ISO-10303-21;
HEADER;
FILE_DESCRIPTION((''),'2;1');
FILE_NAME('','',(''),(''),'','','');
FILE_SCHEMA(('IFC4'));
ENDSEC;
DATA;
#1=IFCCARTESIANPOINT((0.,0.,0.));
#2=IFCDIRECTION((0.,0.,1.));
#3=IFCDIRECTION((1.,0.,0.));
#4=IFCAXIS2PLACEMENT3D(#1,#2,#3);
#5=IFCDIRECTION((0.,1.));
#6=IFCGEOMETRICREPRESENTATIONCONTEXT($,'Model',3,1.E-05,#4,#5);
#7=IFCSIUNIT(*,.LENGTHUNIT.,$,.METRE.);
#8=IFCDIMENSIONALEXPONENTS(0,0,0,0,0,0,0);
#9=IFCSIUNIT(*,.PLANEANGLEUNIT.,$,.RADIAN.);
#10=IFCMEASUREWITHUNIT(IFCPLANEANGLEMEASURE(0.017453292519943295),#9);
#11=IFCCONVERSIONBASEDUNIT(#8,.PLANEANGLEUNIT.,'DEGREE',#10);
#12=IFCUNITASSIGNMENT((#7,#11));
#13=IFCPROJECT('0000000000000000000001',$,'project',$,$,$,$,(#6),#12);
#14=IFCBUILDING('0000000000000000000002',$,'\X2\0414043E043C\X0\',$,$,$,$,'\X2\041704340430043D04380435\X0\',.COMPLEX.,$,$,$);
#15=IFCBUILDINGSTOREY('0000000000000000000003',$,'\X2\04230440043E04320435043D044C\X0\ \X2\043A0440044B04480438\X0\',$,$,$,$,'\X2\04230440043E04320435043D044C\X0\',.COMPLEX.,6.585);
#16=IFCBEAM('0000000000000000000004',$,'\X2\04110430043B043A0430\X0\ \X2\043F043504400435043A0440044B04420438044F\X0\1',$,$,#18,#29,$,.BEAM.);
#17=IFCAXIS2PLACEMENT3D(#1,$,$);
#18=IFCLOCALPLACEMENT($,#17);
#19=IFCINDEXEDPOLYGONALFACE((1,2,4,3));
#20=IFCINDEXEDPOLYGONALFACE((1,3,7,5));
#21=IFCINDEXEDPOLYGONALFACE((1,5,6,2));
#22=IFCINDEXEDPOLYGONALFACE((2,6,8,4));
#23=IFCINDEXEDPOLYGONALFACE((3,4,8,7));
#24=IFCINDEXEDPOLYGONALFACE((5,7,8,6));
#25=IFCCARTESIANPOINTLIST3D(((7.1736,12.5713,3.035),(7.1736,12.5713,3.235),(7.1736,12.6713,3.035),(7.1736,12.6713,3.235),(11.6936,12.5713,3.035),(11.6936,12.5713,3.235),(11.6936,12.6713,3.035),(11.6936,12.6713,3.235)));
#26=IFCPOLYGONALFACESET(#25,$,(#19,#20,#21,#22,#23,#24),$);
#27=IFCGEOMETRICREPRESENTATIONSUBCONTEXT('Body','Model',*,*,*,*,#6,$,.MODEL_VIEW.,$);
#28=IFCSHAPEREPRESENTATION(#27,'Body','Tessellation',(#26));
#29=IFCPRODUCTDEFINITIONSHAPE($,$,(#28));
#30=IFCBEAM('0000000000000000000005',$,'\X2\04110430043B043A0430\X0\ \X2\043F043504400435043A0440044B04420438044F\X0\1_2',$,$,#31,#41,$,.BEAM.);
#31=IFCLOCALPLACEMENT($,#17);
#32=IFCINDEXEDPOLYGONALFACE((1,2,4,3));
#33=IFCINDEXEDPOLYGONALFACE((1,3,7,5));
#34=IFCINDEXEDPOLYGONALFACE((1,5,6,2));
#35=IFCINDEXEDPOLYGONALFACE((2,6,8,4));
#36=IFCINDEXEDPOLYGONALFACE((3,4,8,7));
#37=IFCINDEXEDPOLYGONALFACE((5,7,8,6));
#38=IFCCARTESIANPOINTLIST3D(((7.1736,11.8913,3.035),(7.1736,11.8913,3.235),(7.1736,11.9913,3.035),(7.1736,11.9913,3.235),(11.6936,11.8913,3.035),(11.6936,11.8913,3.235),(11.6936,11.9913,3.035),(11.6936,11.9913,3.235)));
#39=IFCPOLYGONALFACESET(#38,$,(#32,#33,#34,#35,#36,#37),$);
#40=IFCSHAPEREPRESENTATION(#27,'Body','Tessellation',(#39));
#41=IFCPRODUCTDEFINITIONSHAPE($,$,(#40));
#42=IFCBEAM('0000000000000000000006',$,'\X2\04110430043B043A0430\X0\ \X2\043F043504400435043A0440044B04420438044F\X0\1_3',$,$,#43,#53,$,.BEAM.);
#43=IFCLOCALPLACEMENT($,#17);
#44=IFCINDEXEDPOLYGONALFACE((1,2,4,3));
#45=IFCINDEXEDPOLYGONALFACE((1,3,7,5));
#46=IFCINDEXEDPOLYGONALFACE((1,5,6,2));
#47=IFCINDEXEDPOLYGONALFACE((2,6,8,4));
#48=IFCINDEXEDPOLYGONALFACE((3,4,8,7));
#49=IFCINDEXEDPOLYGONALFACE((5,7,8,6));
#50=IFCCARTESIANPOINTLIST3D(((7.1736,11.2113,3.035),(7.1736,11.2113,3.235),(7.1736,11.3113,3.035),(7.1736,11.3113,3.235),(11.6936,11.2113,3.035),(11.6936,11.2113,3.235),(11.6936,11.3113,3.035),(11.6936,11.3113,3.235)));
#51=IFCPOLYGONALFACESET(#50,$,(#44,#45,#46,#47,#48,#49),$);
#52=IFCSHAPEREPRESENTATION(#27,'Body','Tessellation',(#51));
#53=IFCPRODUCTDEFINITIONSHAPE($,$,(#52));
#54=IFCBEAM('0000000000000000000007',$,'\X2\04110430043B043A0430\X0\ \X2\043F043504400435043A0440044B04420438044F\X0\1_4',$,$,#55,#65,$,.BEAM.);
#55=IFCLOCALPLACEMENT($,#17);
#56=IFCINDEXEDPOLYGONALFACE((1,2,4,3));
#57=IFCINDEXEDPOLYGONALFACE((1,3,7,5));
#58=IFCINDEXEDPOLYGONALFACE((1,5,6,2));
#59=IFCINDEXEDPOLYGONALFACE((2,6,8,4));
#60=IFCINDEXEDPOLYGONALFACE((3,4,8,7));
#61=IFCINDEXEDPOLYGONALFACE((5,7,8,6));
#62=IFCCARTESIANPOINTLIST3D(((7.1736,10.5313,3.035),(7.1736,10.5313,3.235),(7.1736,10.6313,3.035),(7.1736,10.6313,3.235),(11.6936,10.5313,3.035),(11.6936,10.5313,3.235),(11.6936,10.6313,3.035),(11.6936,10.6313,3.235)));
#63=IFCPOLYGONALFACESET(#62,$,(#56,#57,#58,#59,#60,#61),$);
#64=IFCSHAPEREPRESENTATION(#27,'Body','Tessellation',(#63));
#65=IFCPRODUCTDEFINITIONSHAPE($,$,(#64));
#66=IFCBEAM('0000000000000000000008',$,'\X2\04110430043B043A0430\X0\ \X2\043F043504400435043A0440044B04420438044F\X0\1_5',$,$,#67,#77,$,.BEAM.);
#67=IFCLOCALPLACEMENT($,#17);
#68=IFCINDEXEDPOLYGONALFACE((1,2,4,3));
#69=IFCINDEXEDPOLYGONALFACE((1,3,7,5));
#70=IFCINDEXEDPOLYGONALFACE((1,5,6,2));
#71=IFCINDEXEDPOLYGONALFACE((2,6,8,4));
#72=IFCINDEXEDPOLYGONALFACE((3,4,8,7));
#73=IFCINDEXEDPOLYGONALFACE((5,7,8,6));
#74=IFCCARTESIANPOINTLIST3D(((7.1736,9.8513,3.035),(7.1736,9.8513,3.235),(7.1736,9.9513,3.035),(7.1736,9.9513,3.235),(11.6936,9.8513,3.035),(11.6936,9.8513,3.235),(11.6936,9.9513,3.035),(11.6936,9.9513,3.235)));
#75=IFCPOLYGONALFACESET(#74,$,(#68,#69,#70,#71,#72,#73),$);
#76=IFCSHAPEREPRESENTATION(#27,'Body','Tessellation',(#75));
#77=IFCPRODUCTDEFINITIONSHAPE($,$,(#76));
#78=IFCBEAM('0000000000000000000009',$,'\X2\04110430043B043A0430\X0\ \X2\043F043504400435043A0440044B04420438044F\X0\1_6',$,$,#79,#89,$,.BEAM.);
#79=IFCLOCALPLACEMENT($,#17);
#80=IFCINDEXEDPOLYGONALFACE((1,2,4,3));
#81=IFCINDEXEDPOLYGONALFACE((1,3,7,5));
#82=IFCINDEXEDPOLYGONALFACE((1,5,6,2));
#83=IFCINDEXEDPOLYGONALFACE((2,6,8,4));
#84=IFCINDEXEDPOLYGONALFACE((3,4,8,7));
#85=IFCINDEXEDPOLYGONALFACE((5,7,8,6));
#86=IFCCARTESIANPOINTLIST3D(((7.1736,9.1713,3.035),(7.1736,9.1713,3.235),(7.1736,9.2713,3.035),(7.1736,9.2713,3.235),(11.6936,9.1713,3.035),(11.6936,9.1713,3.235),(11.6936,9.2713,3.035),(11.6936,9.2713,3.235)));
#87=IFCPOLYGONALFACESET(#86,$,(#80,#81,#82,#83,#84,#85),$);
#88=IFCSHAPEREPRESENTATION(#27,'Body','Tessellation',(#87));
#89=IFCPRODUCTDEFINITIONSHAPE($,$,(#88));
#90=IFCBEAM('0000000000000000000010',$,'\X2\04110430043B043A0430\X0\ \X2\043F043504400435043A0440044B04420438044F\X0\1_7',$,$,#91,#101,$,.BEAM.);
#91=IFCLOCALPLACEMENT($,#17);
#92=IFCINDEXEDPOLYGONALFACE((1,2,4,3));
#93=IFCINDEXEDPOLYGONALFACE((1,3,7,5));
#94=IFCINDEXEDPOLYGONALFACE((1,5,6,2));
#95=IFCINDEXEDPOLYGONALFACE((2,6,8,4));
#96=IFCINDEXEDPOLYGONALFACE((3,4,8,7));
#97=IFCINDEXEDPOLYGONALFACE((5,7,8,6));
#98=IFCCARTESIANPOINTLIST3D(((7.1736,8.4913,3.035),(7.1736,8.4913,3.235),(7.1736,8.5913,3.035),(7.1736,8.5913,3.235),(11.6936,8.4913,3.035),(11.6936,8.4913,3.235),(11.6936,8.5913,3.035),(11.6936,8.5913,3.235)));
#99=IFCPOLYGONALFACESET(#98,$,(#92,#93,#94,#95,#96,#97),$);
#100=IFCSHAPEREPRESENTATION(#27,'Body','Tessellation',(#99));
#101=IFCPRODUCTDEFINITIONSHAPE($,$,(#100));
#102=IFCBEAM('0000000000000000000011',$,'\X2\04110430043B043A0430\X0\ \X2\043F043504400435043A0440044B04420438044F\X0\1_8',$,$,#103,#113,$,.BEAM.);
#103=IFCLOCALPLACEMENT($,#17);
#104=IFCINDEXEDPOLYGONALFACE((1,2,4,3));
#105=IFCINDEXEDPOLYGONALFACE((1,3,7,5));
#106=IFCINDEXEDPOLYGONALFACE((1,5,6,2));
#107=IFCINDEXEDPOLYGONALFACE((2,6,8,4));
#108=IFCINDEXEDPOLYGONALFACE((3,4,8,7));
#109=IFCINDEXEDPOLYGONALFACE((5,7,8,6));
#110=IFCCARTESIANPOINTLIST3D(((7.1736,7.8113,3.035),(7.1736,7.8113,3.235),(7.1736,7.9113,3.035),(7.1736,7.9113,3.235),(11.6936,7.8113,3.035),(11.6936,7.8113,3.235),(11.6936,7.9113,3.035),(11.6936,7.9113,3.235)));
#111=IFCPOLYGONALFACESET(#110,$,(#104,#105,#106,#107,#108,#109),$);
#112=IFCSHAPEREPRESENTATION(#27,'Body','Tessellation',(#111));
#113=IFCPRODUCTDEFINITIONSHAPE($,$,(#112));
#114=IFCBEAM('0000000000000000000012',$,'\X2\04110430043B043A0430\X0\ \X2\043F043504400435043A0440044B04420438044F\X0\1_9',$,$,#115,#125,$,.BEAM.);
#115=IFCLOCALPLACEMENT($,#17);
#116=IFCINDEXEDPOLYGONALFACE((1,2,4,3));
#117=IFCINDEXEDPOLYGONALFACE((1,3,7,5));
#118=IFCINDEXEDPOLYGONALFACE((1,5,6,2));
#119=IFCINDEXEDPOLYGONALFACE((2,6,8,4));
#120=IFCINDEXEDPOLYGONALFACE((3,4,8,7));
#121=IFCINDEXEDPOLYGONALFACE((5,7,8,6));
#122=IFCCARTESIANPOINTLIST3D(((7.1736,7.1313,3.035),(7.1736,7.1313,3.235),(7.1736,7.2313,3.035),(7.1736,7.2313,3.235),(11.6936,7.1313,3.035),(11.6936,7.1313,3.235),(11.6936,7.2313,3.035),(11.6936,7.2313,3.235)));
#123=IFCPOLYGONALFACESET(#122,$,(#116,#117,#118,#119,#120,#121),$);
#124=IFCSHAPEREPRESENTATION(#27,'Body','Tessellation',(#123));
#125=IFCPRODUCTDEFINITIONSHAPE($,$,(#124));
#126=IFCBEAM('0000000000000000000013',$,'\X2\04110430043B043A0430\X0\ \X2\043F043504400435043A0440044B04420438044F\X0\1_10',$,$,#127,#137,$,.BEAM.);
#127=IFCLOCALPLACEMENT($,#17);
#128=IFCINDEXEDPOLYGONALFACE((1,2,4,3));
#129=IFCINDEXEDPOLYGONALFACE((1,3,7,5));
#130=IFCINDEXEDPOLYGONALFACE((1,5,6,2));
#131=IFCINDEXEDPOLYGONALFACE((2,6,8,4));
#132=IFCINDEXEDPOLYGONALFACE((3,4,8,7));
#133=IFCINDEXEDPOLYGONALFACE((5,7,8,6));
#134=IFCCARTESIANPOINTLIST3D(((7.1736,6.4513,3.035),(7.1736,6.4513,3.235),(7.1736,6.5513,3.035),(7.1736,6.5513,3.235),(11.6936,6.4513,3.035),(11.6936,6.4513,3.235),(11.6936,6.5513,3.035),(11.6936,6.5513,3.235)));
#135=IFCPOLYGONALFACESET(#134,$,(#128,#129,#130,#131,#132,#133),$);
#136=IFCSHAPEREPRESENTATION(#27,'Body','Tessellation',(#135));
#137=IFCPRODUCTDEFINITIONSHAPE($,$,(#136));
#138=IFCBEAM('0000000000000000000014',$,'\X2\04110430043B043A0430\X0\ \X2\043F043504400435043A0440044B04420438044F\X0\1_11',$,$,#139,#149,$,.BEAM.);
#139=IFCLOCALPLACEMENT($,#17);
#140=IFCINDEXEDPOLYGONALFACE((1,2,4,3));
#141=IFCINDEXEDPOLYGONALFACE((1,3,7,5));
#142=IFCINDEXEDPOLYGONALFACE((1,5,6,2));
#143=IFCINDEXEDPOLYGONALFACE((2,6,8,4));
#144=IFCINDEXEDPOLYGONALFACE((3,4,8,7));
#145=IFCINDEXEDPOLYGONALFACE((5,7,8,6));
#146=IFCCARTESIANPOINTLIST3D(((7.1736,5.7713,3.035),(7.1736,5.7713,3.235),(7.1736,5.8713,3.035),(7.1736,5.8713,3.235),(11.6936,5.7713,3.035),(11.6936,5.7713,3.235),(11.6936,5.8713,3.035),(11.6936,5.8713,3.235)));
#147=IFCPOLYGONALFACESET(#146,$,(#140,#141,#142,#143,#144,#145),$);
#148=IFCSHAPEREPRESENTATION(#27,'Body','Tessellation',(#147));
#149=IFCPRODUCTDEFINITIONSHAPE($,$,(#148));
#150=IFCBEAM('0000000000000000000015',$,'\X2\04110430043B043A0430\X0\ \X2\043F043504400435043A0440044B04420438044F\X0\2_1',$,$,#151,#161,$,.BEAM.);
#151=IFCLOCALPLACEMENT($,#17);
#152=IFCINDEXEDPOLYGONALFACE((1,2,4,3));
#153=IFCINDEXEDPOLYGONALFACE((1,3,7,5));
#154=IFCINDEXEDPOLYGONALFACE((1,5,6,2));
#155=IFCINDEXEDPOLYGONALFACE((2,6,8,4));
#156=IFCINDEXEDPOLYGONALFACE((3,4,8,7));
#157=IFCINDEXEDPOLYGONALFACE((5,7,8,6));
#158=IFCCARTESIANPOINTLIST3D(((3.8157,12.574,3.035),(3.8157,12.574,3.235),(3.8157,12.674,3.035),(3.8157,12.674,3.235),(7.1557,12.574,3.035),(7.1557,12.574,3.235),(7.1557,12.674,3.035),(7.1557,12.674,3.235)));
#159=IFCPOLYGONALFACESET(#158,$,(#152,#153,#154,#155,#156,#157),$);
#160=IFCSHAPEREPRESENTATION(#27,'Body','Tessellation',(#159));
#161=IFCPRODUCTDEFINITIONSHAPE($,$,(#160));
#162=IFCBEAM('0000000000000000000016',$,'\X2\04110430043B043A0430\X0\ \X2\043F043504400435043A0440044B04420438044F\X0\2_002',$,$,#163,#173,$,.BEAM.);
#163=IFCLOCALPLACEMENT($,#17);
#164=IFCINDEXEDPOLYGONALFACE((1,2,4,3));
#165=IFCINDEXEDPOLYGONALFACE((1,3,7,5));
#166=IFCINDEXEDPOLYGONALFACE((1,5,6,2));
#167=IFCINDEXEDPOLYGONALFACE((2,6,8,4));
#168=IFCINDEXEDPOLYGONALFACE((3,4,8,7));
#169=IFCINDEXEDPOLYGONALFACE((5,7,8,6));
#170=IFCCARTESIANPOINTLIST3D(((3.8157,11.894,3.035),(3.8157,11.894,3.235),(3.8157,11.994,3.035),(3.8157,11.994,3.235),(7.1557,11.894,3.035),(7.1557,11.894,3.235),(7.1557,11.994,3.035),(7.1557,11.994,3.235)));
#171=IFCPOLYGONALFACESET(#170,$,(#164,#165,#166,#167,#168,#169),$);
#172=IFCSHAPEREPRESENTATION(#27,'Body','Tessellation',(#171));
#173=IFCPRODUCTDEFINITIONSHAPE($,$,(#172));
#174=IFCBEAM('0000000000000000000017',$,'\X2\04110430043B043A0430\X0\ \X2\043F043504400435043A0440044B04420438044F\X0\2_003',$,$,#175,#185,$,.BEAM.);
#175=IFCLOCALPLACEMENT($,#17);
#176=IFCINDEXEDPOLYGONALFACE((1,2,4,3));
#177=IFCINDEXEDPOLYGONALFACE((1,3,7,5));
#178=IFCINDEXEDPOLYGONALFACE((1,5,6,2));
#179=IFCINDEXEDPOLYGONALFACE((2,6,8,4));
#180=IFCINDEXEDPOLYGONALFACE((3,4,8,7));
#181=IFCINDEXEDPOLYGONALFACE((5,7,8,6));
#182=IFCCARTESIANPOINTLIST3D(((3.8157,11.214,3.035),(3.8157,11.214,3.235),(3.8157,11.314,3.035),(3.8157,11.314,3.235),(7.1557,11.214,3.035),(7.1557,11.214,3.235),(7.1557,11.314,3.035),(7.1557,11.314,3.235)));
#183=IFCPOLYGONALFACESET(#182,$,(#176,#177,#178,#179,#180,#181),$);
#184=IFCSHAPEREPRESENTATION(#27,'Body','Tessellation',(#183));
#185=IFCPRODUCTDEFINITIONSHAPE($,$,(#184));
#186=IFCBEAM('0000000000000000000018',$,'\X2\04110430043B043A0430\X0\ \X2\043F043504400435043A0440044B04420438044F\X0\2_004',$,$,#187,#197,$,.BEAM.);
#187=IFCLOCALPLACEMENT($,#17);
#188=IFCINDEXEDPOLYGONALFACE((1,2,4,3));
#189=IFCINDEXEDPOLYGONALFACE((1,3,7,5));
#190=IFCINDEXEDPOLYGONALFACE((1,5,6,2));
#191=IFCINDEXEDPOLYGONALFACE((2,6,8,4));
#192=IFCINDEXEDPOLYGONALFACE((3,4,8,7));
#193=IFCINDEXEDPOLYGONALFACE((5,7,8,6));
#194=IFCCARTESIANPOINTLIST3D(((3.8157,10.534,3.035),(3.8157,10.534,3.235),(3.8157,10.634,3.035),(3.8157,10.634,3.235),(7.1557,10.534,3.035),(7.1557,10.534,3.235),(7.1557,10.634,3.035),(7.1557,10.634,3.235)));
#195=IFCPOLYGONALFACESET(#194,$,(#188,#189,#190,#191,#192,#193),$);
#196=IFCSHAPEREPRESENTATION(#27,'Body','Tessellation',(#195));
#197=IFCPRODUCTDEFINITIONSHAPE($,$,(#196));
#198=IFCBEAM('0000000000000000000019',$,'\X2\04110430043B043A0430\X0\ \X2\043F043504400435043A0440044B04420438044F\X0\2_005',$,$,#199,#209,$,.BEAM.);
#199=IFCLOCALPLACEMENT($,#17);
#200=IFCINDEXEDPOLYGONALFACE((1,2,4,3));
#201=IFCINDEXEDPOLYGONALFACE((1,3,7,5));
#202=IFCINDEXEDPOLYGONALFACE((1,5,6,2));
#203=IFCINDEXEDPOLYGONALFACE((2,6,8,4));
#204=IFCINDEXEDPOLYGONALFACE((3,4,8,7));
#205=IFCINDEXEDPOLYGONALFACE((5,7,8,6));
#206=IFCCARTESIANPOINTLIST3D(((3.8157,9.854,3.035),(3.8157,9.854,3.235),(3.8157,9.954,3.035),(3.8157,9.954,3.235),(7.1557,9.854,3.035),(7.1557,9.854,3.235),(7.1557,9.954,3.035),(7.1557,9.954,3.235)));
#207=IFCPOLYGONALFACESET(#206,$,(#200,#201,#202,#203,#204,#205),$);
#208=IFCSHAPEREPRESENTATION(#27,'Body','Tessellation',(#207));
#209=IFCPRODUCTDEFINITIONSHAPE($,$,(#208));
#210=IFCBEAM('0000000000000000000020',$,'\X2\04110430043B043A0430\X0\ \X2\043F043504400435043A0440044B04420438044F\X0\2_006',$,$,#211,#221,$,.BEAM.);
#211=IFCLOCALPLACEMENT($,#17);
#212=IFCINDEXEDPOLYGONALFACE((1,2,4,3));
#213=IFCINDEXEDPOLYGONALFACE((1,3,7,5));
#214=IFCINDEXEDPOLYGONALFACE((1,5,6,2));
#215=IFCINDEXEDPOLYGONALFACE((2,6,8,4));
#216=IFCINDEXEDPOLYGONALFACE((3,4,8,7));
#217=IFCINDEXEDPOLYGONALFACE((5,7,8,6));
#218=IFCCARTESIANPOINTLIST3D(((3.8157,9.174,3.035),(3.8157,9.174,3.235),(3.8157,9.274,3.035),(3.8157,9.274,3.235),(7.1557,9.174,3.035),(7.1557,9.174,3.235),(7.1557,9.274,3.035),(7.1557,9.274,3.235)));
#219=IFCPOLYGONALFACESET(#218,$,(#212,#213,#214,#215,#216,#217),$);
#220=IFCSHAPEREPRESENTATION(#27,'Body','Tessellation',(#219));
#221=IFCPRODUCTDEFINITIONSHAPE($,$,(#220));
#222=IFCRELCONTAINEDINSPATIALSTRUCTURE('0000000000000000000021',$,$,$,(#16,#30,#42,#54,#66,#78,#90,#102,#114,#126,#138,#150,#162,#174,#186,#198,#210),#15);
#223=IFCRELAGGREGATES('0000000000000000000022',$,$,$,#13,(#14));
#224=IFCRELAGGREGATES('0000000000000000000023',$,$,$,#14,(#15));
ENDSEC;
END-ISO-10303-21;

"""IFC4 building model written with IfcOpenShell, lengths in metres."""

from ifc_helpers import new_model, entity, si_unit, converted_unit, direction, frame, frame_2d, origin_with_axes, origin_2d_with_axis, place, context, subcontext, project, spatial, rectangle, extrude, element, save


model = new_model("IFC4")

# Units and contexts
model_context = context("Model", 3, precision=1e-05, world=origin_with_axes(), true_north=direction((0.0, 1.0)))
body_context = subcontext(model_context, "Body", "Model", "MODEL_VIEW")
ifc_project = project(units=[si_unit("LENGTHUNIT", "METRE"), converted_unit("PLANEANGLEUNIT", "DEGREE", entity("IfcPlaneAngleMeasure", 0.017453292519943295), si_unit("PLANEANGLEUNIT", "RADIAN"), dimensions=[0, 0, 0, 0, 0, 0, 0])], contexts=[model_context])

# Building, storey
building = spatial("IfcBuilding", under=ifc_project, Name="Дом", LongName="Здание", CompositionType="COMPLEX")
storey = spatial("IfcBuildingStorey", under=building, Name="Уровень крыши", LongName="Уровень", CompositionType="COMPLEX", Elevation=6.585)

# Beams
placement = place(None, origin_with_axes())
element("IfcBeam", 1, at=placement, inside=storey, Name="Балка перекрытия1", PredefinedType="BEAM", context=body_context, shape_type="SweptSolid", body=[
    extrude(rectangle(XDim=4.52, YDim=0.1, at=origin_2d_with_axis()), frame((9.4336, 12.6213, 3.035), z_axis=(0.0, 0.0, 1.0), x_axis=(1.0, 0.0, 0.0)), (0.0, 0.0, 1.0), 0.2),
])
element("IfcBeam", 2, at=placement, inside=storey, Name="Балка перекрытия1_2", PredefinedType="BEAM", context=body_context, shape_type="SweptSolid", body=[
    extrude(rectangle(XDim=4.52, YDim=0.1, at=origin_2d_with_axis()), frame((9.4336, 11.9413, 3.035), z_axis=(0.0, 0.0, 1.0), x_axis=(1.0, 0.0, 0.0)), (0.0, 0.0, 1.0), 0.2),
])
element("IfcBeam", 3, at=placement, inside=storey, Name="Балка перекрытия1_3", PredefinedType="BEAM", context=body_context, shape_type="SweptSolid", body=[
    extrude(rectangle(XDim=4.52, YDim=0.1, at=origin_2d_with_axis()), frame((9.4336, 11.2613, 3.035), z_axis=(0.0, 0.0, 1.0), x_axis=(1.0, 0.0, 0.0)), (0.0, 0.0, 1.0), 0.2),
])
element("IfcBeam", 4, at=placement, inside=storey, Name="Балка перекрытия1_4", PredefinedType="BEAM", context=body_context, shape_type="SweptSolid", body=[
    extrude(rectangle(XDim=4.52, YDim=0.1, at=origin_2d_with_axis()), frame((9.4336, 10.5813, 3.035), z_axis=(0.0, 0.0, 1.0), x_axis=(1.0, 0.0, 0.0)), (0.0, 0.0, 1.0), 0.2),
])
element("IfcBeam", 5, at=placement, inside=storey, Name="Балка перекрытия1_5", PredefinedType="BEAM", context=body_context, shape_type="SweptSolid", body=[
    extrude(rectangle(XDim=4.52, YDim=0.1, at=origin_2d_with_axis()), frame((9.4336, 9.9013, 3.035), z_axis=(0.0, 0.0, 1.0), x_axis=(1.0, 0.0, 0.0)), (0.0, 0.0, 1.0), 0.2),
])
element("IfcBeam", 6, at=placement, inside=storey, Name="Балка перекрытия1_6", PredefinedType="BEAM", context=body_context, shape_type="SweptSolid", body=[
    extrude(rectangle(XDim=4.52, YDim=0.1, at=origin_2d_with_axis()), frame((9.4336, 9.2213, 3.035), z_axis=(0.0, 0.0, 1.0), x_axis=(1.0, 0.0, 0.0)), (0.0, 0.0, 1.0), 0.2),
])
element("IfcBeam", 7, at=placement, inside=storey, Name="Балка перекрытия1_7", PredefinedType="BEAM", context=body_context, shape_type="SweptSolid", body=[
    extrude(rectangle(XDim=4.52, YDim=0.1, at=origin_2d_with_axis()), frame((9.4336, 8.5413, 3.035), z_axis=(0.0, 0.0, 1.0), x_axis=(1.0, 0.0, 0.0)), (0.0, 0.0, 1.0), 0.2),
])
element("IfcBeam", 8, at=placement, inside=storey, Name="Балка перекрытия1_8", PredefinedType="BEAM", context=body_context, shape_type="SweptSolid", body=[
    extrude(rectangle(XDim=4.52, YDim=0.1, at=origin_2d_with_axis()), frame((9.4336, 7.8613, 3.035), z_axis=(0.0, 0.0, 1.0), x_axis=(1.0, 0.0, 0.0)), (0.0, 0.0, 1.0), 0.2),
])
element("IfcBeam", 9, at=placement, inside=storey, Name="Балка перекрытия1_9", PredefinedType="BEAM", context=body_context, shape_type="SweptSolid", body=[
    extrude(rectangle(XDim=4.52, YDim=0.1, at=origin_2d_with_axis()), frame((9.4336, 7.1813, 3.035), z_axis=(0.0, 0.0, 1.0), x_axis=(1.0, 0.0, 0.0)), (0.0, 0.0, 1.0), 0.2),
])
element("IfcBeam", 10, at=placement, inside=storey, Name="Балка перекрытия1_10", PredefinedType="BEAM", context=body_context, shape_type="SweptSolid", body=[
    extrude(rectangle(XDim=4.52, YDim=0.1, at=origin_2d_with_axis()), frame((9.4336, 6.5013, 3.035), z_axis=(0.0, 0.0, 1.0), x_axis=(1.0, 0.0, 0.0)), (0.0, 0.0, 1.0), 0.2),
])
element("IfcBeam", 11, at=placement, inside=storey, Name="Балка перекрытия1_11", PredefinedType="BEAM", context=body_context, shape_type="SweptSolid", body=[
    extrude(rectangle(XDim=4.52, YDim=0.1, at=origin_2d_with_axis()), frame((9.4336, 5.8213, 3.035), z_axis=(0.0, 0.0, 1.0), x_axis=(1.0, 0.0, 0.0)), (0.0, 0.0, 1.0), 0.2),
])
element("IfcBeam", 12, at=placement, inside=storey, Name="Балка перекрытия2_1", PredefinedType="BEAM", context=body_context, shape_type="SweptSolid", body=[
    extrude(rectangle(XDim=3.34, YDim=0.1, at=frame_2d((0.0, 0.0), x_axis=(1.0, 0.0))), frame((5.4857, 12.624, 3.035), z_axis=(0.0, 0.0, 1.0), x_axis=(1.0, 0.0, 0.0)), (0.0, 0.0, 1.0), 0.2),
])
element("IfcBeam", 13, at=placement, inside=storey, Name="Балка перекрытия2_002", PredefinedType="BEAM", context=body_context, shape_type="SweptSolid", body=[
    extrude(rectangle(XDim=3.34, YDim=0.1, at=frame_2d((0.0, 0.0), x_axis=(1.0, 0.0))), frame((5.4857, 11.944, 3.035), z_axis=(0.0, 0.0, 1.0), x_axis=(1.0, 0.0, 0.0)), (0.0, 0.0, 1.0), 0.2),
])
element("IfcBeam", 14, at=placement, inside=storey, Name="Балка перекрытия2_003", PredefinedType="BEAM", context=body_context, shape_type="SweptSolid", body=[
    extrude(rectangle(XDim=3.34, YDim=0.1, at=frame_2d((0.0, 0.0), x_axis=(1.0, 0.0))), frame((5.4857, 11.264, 3.035), z_axis=(0.0, 0.0, 1.0), x_axis=(1.0, 0.0, 0.0)), (0.0, 0.0, 1.0), 0.2),
])
element("IfcBeam", 15, at=placement, inside=storey, Name="Балка перекрытия2_004", PredefinedType="BEAM", context=body_context, shape_type="SweptSolid", body=[
    extrude(rectangle(XDim=3.34, YDim=0.1, at=frame_2d((0.0, 0.0), x_axis=(1.0, 0.0))), frame((5.4857, 10.584, 3.035), z_axis=(0.0, 0.0, 1.0), x_axis=(1.0, 0.0, 0.0)), (0.0, 0.0, 1.0), 0.2),
])
element("IfcBeam", 16, at=placement, inside=storey, Name="Балка перекрытия2_005", PredefinedType="BEAM", context=body_context, shape_type="SweptSolid", body=[
    extrude(rectangle(XDim=3.34, YDim=0.1, at=frame_2d((0.0, 0.0), x_axis=(1.0, 0.0))), frame((5.4857, 9.904, 3.035), z_axis=(0.0, 0.0, 1.0), x_axis=(1.0, 0.0, 0.0)), (0.0, 0.0, 1.0), 0.2),
])
element("IfcBeam", 17, at=placement, inside=storey, Name="Балка перекрытия2_006", PredefinedType="BEAM", context=body_context, shape_type="SweptSolid", body=[
    extrude(rectangle(XDim=3.34, YDim=0.1, at=frame_2d((0.0, 0.0), x_axis=(1.0, 0.0))), frame((5.4857, 9.224, 3.035), z_axis=(0.0, 0.0, 1.0), x_axis=(1.0, 0.0, 0.0)), (0.0, 0.0, 1.0), 0.2),
])

save(model, "model.ifc")
